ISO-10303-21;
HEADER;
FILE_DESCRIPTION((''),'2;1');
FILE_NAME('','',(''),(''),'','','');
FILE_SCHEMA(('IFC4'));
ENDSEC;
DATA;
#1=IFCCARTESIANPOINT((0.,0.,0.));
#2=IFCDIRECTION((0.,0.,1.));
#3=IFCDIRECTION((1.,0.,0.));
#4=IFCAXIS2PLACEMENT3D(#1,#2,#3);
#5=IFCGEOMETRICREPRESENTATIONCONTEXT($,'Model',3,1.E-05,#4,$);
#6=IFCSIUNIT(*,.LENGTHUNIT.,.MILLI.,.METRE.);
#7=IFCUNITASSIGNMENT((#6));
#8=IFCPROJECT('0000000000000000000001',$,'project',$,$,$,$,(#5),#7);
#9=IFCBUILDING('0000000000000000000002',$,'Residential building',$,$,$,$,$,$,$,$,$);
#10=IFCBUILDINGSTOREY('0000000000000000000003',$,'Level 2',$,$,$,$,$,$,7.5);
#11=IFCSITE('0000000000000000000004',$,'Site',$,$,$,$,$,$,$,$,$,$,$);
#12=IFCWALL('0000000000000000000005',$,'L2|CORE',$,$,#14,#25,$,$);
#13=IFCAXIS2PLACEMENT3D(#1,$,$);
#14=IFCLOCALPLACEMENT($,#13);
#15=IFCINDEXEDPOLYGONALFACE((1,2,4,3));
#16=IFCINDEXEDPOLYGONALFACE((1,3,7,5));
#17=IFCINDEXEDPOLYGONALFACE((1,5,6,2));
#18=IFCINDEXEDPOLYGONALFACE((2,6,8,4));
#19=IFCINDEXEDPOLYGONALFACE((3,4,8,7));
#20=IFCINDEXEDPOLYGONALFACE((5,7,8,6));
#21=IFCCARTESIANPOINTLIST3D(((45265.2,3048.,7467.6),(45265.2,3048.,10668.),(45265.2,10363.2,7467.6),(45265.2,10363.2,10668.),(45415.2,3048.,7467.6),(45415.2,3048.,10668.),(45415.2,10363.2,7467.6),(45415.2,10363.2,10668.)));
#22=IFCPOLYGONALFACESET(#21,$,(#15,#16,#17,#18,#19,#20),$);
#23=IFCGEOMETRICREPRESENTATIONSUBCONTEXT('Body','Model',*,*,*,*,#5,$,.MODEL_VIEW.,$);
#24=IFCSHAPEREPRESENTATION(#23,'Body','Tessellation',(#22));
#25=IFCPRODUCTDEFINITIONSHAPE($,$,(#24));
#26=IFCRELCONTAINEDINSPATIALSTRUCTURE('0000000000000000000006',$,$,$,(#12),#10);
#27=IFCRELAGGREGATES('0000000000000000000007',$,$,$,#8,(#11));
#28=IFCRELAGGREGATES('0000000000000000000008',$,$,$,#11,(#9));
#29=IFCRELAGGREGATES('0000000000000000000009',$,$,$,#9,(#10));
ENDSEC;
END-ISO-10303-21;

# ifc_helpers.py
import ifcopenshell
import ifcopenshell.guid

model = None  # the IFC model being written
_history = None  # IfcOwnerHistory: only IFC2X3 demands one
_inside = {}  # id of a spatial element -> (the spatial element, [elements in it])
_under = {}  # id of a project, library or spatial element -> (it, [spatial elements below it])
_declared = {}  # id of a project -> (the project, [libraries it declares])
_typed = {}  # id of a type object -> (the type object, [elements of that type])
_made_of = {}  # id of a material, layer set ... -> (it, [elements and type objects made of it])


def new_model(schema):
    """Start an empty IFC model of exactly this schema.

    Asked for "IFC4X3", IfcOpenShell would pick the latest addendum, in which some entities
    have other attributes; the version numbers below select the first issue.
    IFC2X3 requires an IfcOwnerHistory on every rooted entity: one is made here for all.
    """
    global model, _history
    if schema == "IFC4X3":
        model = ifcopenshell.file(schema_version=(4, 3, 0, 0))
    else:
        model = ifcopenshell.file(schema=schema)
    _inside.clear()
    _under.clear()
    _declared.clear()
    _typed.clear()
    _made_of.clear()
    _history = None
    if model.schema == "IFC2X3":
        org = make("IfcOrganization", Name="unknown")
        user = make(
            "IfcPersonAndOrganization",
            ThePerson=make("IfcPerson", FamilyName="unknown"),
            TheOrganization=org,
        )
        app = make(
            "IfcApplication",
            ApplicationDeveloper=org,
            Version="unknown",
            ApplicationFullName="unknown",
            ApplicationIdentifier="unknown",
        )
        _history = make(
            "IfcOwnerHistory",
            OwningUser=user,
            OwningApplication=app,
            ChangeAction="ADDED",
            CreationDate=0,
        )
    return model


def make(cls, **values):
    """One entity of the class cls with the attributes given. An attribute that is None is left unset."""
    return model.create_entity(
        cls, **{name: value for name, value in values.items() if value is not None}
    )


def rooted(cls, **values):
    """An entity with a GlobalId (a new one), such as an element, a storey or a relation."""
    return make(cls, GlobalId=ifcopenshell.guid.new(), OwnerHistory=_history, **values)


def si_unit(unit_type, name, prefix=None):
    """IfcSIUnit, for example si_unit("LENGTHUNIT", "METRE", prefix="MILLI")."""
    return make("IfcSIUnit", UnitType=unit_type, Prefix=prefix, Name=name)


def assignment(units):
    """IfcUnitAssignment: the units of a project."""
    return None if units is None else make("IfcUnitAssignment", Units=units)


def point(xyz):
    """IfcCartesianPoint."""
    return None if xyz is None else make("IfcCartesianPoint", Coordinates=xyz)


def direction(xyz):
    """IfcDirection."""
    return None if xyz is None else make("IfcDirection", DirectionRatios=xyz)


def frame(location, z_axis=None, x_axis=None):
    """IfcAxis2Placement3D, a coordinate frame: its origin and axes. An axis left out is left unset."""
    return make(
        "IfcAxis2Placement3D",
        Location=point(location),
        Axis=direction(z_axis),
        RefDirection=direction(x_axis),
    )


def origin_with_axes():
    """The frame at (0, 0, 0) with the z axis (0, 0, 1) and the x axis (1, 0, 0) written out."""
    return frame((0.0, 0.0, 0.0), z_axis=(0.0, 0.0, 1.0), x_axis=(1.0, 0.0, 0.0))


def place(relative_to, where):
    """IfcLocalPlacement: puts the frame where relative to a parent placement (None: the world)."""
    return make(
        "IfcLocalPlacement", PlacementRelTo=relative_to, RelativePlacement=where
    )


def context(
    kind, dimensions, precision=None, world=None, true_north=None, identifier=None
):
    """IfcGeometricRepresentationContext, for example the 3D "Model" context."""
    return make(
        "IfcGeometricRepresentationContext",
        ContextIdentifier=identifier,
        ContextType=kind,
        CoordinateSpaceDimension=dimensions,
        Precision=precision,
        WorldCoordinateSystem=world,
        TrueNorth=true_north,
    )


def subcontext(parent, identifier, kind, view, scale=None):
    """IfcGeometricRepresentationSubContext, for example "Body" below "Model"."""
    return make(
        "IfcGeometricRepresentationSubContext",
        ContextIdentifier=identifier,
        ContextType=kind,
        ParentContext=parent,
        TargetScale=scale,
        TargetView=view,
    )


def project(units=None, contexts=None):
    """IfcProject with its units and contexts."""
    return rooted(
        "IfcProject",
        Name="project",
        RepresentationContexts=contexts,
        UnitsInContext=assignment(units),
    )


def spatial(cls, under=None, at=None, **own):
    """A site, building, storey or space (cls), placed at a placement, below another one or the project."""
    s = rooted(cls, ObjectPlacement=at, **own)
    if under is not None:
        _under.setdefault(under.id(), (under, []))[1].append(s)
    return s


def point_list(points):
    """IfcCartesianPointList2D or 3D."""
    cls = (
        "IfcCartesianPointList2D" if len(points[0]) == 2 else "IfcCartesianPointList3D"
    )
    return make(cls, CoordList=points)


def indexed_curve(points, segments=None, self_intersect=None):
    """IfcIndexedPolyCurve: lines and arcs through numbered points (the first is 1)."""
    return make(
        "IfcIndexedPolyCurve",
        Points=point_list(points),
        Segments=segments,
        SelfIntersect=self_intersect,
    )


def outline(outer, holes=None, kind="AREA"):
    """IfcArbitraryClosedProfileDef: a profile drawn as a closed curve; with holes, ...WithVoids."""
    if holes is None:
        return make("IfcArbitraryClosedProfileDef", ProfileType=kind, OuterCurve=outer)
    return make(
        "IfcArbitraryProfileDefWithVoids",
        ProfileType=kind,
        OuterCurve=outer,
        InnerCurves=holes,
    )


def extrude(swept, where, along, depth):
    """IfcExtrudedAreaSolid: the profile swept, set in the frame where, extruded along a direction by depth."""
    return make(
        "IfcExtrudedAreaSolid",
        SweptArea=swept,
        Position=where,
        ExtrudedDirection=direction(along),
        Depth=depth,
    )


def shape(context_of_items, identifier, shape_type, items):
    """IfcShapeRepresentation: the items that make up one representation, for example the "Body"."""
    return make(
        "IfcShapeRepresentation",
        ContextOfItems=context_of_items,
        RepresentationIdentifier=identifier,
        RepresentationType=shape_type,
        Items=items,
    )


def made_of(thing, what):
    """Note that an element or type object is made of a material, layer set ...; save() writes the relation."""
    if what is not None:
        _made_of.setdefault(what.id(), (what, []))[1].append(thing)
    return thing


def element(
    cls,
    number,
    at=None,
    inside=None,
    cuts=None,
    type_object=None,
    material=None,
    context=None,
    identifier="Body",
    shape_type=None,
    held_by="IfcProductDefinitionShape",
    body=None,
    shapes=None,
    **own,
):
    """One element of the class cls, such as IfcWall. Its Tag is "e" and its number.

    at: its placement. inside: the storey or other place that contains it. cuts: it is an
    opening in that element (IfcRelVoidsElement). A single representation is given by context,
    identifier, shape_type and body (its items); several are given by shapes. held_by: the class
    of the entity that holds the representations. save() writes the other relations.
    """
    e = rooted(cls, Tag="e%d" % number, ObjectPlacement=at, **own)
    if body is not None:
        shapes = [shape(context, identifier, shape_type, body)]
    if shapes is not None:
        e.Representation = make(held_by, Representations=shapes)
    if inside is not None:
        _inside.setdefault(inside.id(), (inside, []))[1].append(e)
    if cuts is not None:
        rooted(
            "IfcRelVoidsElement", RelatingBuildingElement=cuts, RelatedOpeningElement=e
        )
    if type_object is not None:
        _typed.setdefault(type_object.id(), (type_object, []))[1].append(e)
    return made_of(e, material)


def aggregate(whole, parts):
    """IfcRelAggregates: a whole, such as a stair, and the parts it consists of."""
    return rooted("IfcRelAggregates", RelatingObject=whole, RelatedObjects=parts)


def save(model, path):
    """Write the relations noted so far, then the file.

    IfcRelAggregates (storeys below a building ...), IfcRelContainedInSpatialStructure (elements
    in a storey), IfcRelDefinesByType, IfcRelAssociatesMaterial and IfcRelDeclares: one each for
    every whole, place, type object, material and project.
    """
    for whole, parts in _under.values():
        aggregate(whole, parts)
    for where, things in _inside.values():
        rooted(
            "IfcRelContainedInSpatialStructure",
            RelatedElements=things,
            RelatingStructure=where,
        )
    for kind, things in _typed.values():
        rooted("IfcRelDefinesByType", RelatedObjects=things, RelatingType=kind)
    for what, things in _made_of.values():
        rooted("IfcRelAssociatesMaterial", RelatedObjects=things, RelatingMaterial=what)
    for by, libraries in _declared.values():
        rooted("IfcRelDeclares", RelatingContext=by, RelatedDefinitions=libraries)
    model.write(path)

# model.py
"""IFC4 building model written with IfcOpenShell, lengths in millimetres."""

from ifc_helpers import new_model, si_unit, frame, origin_with_axes, place, context, subcontext, project, spatial, indexed_curve, outline, extrude, element, save


model = new_model("IFC4")

# Units and contexts
model_context = context("Model", 3, precision=1e-05, world=origin_with_axes())
body_context = subcontext(model_context, "Body", "Model", "MODEL_VIEW")
ifc_project = project(units=[si_unit("LENGTHUNIT", "METRE", prefix="MILLI")], contexts=[model_context])

# Site, building, storey
site = spatial("IfcSite", under=ifc_project, Name="Site")
building = spatial("IfcBuilding", under=site, Name="Residential building")
storey = spatial("IfcBuildingStorey", under=building, Name="Level 2", Elevation=7.5)

# Wall
for number, where, z_axis, x_axis, name in (
    (1, (45415.2, 3048.0, 7467.6), (0.0, 0.0, 1.0), (0.0, 1.0, 0.0), "L2|CORE"),
):
    element("IfcWall", number, at=place(None, frame(where, z_axis=z_axis, x_axis=x_axis)), inside=storey, Name=name, context=body_context, shape_type="SweptSolid", body=[
        extrude(outline(indexed_curve([(0.0, 0.0), (0.0, 150.0), (7315.2, 150.0), (7315.2, 0.0), (0.0, 0.0)], self_intersect=False)), origin_with_axes(), (0.0, 0.0, 1.0), 3200.4),
    ])

save(model, "model.ifc")
